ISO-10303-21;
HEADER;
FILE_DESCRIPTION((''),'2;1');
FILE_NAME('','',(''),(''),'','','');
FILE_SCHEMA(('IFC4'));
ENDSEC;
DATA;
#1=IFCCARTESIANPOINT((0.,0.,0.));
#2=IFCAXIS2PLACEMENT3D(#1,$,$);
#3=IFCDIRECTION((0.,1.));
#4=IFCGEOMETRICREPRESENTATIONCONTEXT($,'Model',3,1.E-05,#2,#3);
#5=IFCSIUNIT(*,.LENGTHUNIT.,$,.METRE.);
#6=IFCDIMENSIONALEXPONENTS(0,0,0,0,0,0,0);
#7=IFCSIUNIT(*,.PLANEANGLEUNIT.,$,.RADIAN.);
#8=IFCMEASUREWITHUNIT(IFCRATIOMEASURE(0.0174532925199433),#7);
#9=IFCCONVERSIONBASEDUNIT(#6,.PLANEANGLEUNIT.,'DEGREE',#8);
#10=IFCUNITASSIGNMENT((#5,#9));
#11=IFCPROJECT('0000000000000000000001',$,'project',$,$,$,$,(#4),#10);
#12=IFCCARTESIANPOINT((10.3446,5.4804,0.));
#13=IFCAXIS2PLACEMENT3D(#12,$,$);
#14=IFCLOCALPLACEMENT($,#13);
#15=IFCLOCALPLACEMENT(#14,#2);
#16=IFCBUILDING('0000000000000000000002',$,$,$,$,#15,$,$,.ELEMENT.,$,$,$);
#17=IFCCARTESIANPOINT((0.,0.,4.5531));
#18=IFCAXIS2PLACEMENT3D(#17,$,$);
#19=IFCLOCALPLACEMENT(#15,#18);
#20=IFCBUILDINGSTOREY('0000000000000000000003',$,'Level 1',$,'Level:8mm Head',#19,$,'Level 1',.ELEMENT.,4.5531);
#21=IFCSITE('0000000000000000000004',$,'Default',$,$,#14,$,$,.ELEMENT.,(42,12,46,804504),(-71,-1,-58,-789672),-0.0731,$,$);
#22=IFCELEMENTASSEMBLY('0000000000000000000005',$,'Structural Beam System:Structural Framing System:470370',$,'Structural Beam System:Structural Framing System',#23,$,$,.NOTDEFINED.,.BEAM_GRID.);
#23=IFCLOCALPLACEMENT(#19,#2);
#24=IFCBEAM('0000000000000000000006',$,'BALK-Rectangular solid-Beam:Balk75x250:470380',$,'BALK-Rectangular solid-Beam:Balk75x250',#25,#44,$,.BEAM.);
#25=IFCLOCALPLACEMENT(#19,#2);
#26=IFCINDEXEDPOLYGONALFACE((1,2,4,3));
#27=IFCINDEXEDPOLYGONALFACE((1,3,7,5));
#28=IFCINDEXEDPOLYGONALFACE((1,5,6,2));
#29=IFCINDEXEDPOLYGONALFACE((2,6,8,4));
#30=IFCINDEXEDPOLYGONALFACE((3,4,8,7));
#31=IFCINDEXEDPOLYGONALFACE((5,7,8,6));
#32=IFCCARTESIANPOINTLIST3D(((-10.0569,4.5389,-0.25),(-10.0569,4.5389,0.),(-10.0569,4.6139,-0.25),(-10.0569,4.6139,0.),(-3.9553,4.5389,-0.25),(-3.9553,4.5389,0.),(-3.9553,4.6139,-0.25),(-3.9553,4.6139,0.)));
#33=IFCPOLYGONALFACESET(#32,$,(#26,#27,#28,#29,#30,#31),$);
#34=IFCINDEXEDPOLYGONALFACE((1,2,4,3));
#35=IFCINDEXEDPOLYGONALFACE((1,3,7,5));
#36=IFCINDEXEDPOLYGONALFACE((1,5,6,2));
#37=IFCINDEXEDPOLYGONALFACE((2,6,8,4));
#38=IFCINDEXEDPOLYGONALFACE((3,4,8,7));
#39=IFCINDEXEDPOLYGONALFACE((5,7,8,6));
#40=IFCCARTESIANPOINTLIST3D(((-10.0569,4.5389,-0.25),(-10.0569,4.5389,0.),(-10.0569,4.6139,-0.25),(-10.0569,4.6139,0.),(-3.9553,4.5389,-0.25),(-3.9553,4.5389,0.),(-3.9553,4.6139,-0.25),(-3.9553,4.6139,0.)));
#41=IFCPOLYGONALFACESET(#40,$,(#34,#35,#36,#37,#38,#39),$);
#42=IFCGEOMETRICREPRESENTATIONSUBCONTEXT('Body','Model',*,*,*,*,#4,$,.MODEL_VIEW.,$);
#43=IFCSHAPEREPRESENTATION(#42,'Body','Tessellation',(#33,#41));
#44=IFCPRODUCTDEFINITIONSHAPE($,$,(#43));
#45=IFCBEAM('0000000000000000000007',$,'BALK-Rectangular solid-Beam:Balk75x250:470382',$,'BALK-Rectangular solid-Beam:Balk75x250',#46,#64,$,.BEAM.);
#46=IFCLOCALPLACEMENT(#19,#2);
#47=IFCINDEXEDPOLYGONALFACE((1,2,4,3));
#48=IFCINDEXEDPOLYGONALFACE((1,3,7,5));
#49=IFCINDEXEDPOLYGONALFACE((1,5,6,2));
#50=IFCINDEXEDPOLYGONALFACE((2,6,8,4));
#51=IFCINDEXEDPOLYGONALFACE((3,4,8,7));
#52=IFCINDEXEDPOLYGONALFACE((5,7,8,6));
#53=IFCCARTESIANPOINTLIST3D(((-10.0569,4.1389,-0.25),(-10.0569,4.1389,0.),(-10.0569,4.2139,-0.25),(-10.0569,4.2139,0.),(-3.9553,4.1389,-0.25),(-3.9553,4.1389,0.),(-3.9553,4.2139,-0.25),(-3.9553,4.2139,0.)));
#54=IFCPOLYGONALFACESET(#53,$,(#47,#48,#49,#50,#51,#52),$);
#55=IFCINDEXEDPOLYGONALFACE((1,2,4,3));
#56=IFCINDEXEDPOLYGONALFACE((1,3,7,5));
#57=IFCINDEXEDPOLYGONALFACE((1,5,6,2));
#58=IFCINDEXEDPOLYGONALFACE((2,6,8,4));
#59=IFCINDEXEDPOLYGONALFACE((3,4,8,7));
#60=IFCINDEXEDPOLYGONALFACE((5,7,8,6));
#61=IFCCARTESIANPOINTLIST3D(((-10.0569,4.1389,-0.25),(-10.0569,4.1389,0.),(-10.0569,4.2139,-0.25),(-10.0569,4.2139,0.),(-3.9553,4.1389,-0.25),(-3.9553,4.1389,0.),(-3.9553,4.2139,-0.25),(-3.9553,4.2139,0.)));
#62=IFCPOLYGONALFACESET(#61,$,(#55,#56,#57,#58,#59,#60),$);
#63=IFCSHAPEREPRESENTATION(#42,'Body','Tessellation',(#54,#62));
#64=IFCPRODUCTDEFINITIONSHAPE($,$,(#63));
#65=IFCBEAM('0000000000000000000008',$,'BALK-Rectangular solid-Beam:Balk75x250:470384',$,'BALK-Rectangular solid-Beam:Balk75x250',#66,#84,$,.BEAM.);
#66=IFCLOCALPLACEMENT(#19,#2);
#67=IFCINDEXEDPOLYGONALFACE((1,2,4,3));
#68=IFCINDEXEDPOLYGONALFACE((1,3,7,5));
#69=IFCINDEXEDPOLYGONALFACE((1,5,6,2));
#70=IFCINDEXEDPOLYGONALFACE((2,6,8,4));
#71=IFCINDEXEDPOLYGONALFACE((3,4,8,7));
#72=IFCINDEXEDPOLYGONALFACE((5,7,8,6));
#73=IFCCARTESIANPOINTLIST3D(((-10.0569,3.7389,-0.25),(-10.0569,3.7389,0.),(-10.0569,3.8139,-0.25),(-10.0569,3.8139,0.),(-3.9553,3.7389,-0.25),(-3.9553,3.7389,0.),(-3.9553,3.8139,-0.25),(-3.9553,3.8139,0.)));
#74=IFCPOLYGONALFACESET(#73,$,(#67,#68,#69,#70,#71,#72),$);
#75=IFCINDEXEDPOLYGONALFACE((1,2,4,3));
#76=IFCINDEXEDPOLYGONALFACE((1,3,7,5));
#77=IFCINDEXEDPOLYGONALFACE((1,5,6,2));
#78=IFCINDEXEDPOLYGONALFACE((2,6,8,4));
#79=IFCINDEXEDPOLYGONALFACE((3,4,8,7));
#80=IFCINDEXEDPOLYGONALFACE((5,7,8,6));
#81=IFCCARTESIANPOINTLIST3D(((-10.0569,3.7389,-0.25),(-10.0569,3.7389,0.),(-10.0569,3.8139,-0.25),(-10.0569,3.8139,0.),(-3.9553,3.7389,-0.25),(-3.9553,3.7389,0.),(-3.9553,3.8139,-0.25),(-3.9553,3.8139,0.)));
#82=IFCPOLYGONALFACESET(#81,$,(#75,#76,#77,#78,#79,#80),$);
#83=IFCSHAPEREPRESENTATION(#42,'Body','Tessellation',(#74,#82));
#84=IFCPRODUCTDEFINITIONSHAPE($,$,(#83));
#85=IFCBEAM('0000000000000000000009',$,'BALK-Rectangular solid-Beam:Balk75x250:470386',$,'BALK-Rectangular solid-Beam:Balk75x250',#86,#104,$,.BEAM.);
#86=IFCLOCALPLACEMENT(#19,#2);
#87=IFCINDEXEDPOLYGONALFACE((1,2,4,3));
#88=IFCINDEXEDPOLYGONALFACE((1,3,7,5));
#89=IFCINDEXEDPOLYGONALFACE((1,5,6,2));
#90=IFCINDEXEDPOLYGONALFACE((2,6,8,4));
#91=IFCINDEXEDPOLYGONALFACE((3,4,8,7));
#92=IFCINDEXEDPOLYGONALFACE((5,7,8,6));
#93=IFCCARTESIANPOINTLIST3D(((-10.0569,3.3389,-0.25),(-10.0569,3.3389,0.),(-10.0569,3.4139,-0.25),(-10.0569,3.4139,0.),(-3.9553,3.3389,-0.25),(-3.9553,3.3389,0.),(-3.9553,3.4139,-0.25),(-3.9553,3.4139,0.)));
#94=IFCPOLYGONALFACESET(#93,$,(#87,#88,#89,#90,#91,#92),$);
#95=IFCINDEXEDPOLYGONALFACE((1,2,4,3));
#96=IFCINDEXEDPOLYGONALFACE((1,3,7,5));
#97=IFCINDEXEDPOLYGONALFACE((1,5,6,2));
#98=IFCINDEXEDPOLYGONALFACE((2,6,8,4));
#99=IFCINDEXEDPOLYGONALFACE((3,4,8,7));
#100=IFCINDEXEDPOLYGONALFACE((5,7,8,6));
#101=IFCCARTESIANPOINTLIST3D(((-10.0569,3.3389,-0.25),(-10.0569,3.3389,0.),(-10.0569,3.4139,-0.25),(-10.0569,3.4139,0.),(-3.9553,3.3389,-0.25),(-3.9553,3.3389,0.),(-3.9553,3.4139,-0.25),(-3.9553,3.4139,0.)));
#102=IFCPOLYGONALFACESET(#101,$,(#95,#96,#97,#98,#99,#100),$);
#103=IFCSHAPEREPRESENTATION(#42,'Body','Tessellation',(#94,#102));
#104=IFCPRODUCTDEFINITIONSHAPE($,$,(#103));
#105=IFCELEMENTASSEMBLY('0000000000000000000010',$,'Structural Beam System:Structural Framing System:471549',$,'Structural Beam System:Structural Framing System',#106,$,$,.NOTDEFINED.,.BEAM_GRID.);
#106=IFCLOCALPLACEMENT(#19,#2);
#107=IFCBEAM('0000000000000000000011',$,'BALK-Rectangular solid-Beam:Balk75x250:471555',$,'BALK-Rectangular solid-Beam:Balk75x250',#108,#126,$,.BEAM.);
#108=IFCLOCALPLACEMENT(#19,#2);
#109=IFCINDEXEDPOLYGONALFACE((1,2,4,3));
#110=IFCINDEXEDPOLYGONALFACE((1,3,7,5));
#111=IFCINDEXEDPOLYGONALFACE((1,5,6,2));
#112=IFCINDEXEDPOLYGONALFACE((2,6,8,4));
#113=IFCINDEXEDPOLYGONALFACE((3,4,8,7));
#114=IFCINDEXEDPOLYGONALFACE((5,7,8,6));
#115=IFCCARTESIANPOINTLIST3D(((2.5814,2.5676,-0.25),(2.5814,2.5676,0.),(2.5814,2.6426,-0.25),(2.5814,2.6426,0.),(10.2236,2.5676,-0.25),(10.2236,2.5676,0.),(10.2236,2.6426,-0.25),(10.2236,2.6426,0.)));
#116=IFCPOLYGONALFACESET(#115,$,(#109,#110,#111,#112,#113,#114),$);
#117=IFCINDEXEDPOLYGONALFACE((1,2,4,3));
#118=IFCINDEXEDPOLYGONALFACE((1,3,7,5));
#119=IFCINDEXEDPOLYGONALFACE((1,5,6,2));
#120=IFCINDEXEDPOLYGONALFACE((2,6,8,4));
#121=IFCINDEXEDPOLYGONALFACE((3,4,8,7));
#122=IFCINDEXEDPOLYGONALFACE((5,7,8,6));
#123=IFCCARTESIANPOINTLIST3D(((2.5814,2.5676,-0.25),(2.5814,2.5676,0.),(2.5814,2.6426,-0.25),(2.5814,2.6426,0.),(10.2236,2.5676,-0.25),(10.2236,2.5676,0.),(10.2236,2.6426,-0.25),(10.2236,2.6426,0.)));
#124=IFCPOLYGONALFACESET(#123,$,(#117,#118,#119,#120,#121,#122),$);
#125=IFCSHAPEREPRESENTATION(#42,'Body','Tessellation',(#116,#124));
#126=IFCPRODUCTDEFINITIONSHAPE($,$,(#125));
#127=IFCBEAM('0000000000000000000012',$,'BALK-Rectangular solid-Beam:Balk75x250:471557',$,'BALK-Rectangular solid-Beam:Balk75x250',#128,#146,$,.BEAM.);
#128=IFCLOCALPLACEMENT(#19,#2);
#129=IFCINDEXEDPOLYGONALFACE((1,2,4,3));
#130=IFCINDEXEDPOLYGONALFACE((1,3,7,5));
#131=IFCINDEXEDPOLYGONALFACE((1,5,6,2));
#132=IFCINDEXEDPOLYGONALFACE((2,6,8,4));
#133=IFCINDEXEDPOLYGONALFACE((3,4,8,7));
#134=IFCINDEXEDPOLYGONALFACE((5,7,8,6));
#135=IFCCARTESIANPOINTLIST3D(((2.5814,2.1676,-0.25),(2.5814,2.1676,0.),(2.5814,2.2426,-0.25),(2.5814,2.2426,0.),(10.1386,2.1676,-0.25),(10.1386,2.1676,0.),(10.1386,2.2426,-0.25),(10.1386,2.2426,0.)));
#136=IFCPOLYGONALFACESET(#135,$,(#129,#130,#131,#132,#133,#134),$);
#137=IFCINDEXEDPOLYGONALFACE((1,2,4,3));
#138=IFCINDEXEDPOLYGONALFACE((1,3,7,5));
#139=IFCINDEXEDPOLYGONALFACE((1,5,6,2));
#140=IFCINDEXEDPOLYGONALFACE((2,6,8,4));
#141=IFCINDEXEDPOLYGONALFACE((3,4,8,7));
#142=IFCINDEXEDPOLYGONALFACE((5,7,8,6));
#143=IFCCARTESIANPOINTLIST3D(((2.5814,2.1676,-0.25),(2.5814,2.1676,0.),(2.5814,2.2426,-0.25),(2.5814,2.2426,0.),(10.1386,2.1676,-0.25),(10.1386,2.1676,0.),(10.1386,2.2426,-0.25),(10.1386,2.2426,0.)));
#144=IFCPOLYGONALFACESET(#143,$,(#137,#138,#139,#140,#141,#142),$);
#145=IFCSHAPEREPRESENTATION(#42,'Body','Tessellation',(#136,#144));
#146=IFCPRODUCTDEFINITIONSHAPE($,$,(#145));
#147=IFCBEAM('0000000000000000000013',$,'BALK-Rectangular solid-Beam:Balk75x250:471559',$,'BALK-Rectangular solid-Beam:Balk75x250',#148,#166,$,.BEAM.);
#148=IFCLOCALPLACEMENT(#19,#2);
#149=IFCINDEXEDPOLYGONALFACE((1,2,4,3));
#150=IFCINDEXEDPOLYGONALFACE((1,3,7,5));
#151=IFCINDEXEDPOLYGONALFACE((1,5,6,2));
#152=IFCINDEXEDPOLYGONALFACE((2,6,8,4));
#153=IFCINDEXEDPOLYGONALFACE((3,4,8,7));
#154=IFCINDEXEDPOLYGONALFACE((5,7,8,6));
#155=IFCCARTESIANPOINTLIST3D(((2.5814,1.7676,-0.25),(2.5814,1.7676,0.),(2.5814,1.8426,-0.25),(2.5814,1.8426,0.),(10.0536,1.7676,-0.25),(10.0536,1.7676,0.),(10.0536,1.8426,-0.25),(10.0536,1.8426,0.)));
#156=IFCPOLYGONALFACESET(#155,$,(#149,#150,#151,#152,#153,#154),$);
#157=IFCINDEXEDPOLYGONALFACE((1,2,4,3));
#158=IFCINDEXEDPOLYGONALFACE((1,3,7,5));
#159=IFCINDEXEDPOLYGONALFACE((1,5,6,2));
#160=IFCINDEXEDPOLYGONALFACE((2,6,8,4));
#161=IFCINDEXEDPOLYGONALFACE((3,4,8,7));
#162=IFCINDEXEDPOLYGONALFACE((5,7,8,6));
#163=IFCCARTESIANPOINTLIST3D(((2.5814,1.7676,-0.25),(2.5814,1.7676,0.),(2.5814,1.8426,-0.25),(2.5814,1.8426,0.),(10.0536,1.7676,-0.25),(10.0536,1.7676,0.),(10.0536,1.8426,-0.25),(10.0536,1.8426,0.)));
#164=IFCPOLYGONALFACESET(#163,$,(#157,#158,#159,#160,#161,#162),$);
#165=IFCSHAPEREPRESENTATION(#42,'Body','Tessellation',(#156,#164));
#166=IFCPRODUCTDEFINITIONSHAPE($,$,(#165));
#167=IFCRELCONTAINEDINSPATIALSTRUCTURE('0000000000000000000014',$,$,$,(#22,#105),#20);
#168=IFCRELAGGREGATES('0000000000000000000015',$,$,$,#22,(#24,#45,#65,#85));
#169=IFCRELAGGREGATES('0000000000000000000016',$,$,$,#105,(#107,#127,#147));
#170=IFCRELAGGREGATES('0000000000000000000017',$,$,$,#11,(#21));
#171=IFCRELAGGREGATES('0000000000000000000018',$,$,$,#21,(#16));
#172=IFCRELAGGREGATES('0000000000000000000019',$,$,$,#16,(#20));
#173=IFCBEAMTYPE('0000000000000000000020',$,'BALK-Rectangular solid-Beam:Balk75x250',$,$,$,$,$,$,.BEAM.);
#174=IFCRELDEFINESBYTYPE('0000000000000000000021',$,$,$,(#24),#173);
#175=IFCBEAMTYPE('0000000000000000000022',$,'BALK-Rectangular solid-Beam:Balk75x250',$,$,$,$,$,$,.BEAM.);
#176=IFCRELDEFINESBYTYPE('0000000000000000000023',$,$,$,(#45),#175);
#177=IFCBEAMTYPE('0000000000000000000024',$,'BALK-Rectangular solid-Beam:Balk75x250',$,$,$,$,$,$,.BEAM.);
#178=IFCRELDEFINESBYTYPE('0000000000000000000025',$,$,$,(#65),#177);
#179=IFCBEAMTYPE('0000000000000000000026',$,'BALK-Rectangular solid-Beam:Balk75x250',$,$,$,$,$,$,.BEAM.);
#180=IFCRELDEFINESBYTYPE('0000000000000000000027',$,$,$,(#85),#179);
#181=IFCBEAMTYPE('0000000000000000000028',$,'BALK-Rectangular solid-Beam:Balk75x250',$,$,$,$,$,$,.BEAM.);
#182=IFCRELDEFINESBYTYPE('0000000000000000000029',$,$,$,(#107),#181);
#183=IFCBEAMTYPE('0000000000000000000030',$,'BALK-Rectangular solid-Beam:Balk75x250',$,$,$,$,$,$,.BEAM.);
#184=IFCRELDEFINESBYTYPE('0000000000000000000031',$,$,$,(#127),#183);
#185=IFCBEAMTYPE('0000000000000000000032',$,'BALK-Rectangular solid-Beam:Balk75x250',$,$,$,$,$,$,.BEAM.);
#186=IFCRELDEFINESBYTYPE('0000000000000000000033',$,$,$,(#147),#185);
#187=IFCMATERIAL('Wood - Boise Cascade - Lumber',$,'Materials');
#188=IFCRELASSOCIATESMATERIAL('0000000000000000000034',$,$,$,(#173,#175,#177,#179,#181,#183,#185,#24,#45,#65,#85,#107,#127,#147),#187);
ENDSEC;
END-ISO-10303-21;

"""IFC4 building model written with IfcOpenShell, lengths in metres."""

from ifc_helpers import new_model, entity, si_unit, converted_unit, direction, frame, frame_2d, origin, place, context, subcontext, project, spatial, rectangle, extrude, source, transform, mapped, material, material_profile, profile_set, profile_usage, type_object, type_shapes, element, aggregate, save


model = new_model("IFC4")

# Units and contexts
model_context = context("Model", 3, precision=1e-05, world=origin(), true_north=direction((0.0, 1.0)))
body_context = subcontext(model_context, "Body", "Model", "MODEL_VIEW")
ifc_project = project(units=[si_unit("LENGTHUNIT", "METRE"), converted_unit("PLANEANGLEUNIT", "DEGREE", entity("IfcRatioMeasure", 0.0174532925199433), si_unit("PLANEANGLEUNIT", "RADIAN"), dimensions=[0, 0, 0, 0, 0, 0, 0])], contexts=[model_context])

# Site, building, storey
site_placement = place(None, frame((10.3446, 5.4804, 0.0)))
site = spatial("IfcSite", under=ifc_project, at=site_placement, Name="Default", CompositionType="ELEMENT", RefLatitude=(42, 12, 46, 804504), RefLongitude=(-71, -1, -58, -789672), RefElevation=-0.0731)
building_placement = place(site_placement, origin())
building = spatial("IfcBuilding", under=site, at=building_placement, CompositionType="ELEMENT")
storey_placement = place(building_placement, frame((0.0, 0.0, 4.5531)))
storey = spatial("IfcBuildingStorey", under=building, at=storey_placement, Name="Level 1", ObjectType="Level:8mm Head", LongName="Level 1", CompositionType="ELEMENT", Elevation=4.5531)

# Element assemblies, beams
assembly_1_placement = place(storey_placement, origin())
assembly_1 = element("IfcElementAssembly", 1, at=assembly_1_placement, inside=storey, Name="Structural Beam System:Structural Framing System:470370", ObjectType="Structural Beam System:Structural Framing System", AssemblyPlace="NOTDEFINED", PredefinedType="BEAM_GRID")
ifc_material = material(Name="Wood - Boise Cascade - Lumber", Category="Materials")
ifc_material_profile = material_profile(ifc_material, rectangle(XDim=0.25, YDim=0.075, at=frame_2d((0.0, 0.0), x_axis=(1.0, 0.0))), Name="Balk75x250")
ifc_profile_set = profile_set([ifc_material_profile], Name="Balk75x250")
ifc_profile_usage_1 = profile_usage(ifc_profile_set, cardinal=8)
beam_type_1 = type_object("IfcBeamType", Name="BALK-Rectangular solid-Beam:Balk75x250", PredefinedType="BEAM", material=ifc_profile_set)
shared_shape_1 = source(origin(), body_context, "Body", "SweptSolid", [
    extrude(rectangle(XDim=0.25, YDim=0.075, at=frame_2d((0.0, 0.0), x_axis=(1.0, 0.0))), frame((-10.0569, 4.5764, 4.4281), z_axis=(1.0, 0.0, 0.0), x_axis=(0.0, 0.0, -1.0)), (0.0, 0.0, 1.0), 6.1016),
    extrude(rectangle(XDim=0.25, YDim=0.075, at=frame_2d((0.0, 0.0), x_axis=(1.0, 0.0))), frame((-10.0569, 4.5764, 4.4281), z_axis=(1.0, 0.0, 0.0), x_axis=(0.0, 0.0, -1.0)), (0.0, 0.0, 1.0), 6.1016),
])
type_shapes(beam_type_1, [shared_shape_1])
beam_1_placement = place(assembly_1_placement, frame((0.0, 0.0, -4.5531)))
beam_1 = element("IfcBeam", 2, at=beam_1_placement, type_object=beam_type_1, material=ifc_profile_usage_1, Name="BALK-Rectangular solid-Beam:Balk75x250:470380", ObjectType="BALK-Rectangular solid-Beam:Balk75x250", PredefinedType="BEAM", context=body_context, shape_type="MappedRepresentation", body=[
    mapped(shared_shape_1, transform((0.0, 0.0, 0.0), scale=1.0)),
])
ifc_profile_usage_2 = profile_usage(ifc_profile_set, cardinal=8)
beam_type_2 = type_object("IfcBeamType", Name="BALK-Rectangular solid-Beam:Balk75x250", PredefinedType="BEAM", material=ifc_profile_set)
shared_shape_2 = source(origin(), body_context, "Body", "SweptSolid", [
    extrude(rectangle(XDim=0.25, YDim=0.075, at=frame_2d((0.0, 0.0), x_axis=(1.0, 0.0))), frame((-10.0569, 4.1764, 4.4281), z_axis=(1.0, 0.0, 0.0), x_axis=(0.0, 0.0, -1.0)), (0.0, 0.0, 1.0), 6.1016),
    extrude(rectangle(XDim=0.25, YDim=0.075, at=frame_2d((0.0, 0.0), x_axis=(1.0, 0.0))), frame((-10.0569, 4.1764, 4.4281), z_axis=(1.0, 0.0, 0.0), x_axis=(0.0, 0.0, -1.0)), (0.0, 0.0, 1.0), 6.1016),
])
type_shapes(beam_type_2, [shared_shape_2])
beam_2_placement = place(assembly_1_placement, frame((0.0, 0.0, -4.5531)))
beam_2 = element("IfcBeam", 3, at=beam_2_placement, type_object=beam_type_2, material=ifc_profile_usage_2, Name="BALK-Rectangular solid-Beam:Balk75x250:470382", ObjectType="BALK-Rectangular solid-Beam:Balk75x250", PredefinedType="BEAM", context=body_context, shape_type="MappedRepresentation", body=[
    mapped(shared_shape_2, transform((0.0, 0.0, 0.0), scale=1.0)),
])
ifc_profile_usage_3 = profile_usage(ifc_profile_set, cardinal=8)
beam_type_3 = type_object("IfcBeamType", Name="BALK-Rectangular solid-Beam:Balk75x250", PredefinedType="BEAM", material=ifc_profile_set)
shared_shape_3 = source(origin(), body_context, "Body", "SweptSolid", [
    extrude(rectangle(XDim=0.25, YDim=0.075, at=frame_2d((0.0, 0.0), x_axis=(1.0, 0.0))), frame((-10.0569, 3.7764, 4.4281), z_axis=(1.0, 0.0, 0.0), x_axis=(0.0, 0.0, -1.0)), (0.0, 0.0, 1.0), 6.1016),
    extrude(rectangle(XDim=0.25, YDim=0.075, at=frame_2d((0.0, 0.0), x_axis=(1.0, 0.0))), frame((-10.0569, 3.7764, 4.4281), z_axis=(1.0, 0.0, 0.0), x_axis=(0.0, 0.0, -1.0)), (0.0, 0.0, 1.0), 6.1016),
])
type_shapes(beam_type_3, [shared_shape_3])
beam_3_placement = place(assembly_1_placement, frame((0.0, 0.0, -4.5531)))
beam_3 = element("IfcBeam", 4, at=beam_3_placement, type_object=beam_type_3, material=ifc_profile_usage_3, Name="BALK-Rectangular solid-Beam:Balk75x250:470384", ObjectType="BALK-Rectangular solid-Beam:Balk75x250", PredefinedType="BEAM", context=body_context, shape_type="MappedRepresentation", body=[
    mapped(shared_shape_3, transform((0.0, 0.0, 0.0), scale=1.0)),
])
ifc_profile_usage_4 = profile_usage(ifc_profile_set, cardinal=8)
beam_type_4 = type_object("IfcBeamType", Name="BALK-Rectangular solid-Beam:Balk75x250", PredefinedType="BEAM", material=ifc_profile_set)
shared_shape_4 = source(origin(), body_context, "Body", "SweptSolid", [
    extrude(rectangle(XDim=0.25, YDim=0.075, at=frame_2d((0.0, 0.0), x_axis=(1.0, 0.0))), frame((-10.0569, 3.3764, 4.4281), z_axis=(1.0, 0.0, 0.0), x_axis=(0.0, 0.0, -1.0)), (0.0, 0.0, 1.0), 6.1016),
    extrude(rectangle(XDim=0.25, YDim=0.075, at=frame_2d((0.0, 0.0), x_axis=(1.0, 0.0))), frame((-10.0569, 3.3764, 4.4281), z_axis=(1.0, 0.0, 0.0), x_axis=(0.0, 0.0, -1.0)), (0.0, 0.0, 1.0), 6.1016),
])
type_shapes(beam_type_4, [shared_shape_4])
beam_4_placement = place(assembly_1_placement, frame((0.0, 0.0, -4.5531)))
beam_4 = element("IfcBeam", 5, at=beam_4_placement, type_object=beam_type_4, material=ifc_profile_usage_4, Name="BALK-Rectangular solid-Beam:Balk75x250:470386", ObjectType="BALK-Rectangular solid-Beam:Balk75x250", PredefinedType="BEAM", context=body_context, shape_type="MappedRepresentation", body=[
    mapped(shared_shape_4, transform((0.0, 0.0, 0.0), scale=1.0)),
])
aggregate(assembly_1, [beam_1, beam_2, beam_3, beam_4])
assembly_2_placement = place(storey_placement, origin())
assembly_2 = element("IfcElementAssembly", 6, at=assembly_2_placement, inside=storey, Name="Structural Beam System:Structural Framing System:471549", ObjectType="Structural Beam System:Structural Framing System", AssemblyPlace="NOTDEFINED", PredefinedType="BEAM_GRID")
ifc_profile_usage_5 = profile_usage(ifc_profile_set, cardinal=8)
beam_type_5 = type_object("IfcBeamType", Name="BALK-Rectangular solid-Beam:Balk75x250", PredefinedType="BEAM", material=ifc_profile_set)
shared_shape_5 = source(origin(), body_context, "Body", "SweptSolid", [
    extrude(rectangle(XDim=0.25, YDim=0.075, at=frame_2d((0.0, 0.0), x_axis=(1.0, 0.0))), frame((2.5814, 2.6051, 4.4281), z_axis=(1.0, 0.0, 0.0), x_axis=(0.0, 0.0, -1.0)), (0.0, 0.0, 1.0), 7.6423),
    extrude(rectangle(XDim=0.25, YDim=0.075, at=frame_2d((0.0, 0.0), x_axis=(1.0, 0.0))), frame((2.5814, 2.6051, 4.4281), z_axis=(1.0, 0.0, 0.0), x_axis=(0.0, 0.0, -1.0)), (0.0, 0.0, 1.0), 7.6423),
])
type_shapes(beam_type_5, [shared_shape_5])
beam_5_placement = place(assembly_2_placement, frame((0.0, 0.0, -4.5531)))
beam_5 = element("IfcBeam", 7, at=beam_5_placement, type_object=beam_type_5, material=ifc_profile_usage_5, Name="BALK-Rectangular solid-Beam:Balk75x250:471555", ObjectType="BALK-Rectangular solid-Beam:Balk75x250", PredefinedType="BEAM", context=body_context, shape_type="MappedRepresentation", body=[
    mapped(shared_shape_5, transform((0.0, 0.0, 0.0), scale=1.0)),
])
ifc_profile_usage_6 = profile_usage(ifc_profile_set, cardinal=8)
beam_type_6 = type_object("IfcBeamType", Name="BALK-Rectangular solid-Beam:Balk75x250", PredefinedType="BEAM", material=ifc_profile_set)
shared_shape_6 = source(origin(), body_context, "Body", "SweptSolid", [
    extrude(rectangle(XDim=0.25, YDim=0.075, at=frame_2d((0.0, 0.0), x_axis=(1.0, 0.0))), frame((2.5814, 2.2051, 4.4281), z_axis=(1.0, 0.0, 0.0), x_axis=(0.0, 0.0, -1.0)), (0.0, 0.0, 1.0), 7.5573),
    extrude(rectangle(XDim=0.25, YDim=0.075, at=frame_2d((0.0, 0.0), x_axis=(1.0, 0.0))), frame((2.5814, 2.2051, 4.4281), z_axis=(1.0, 0.0, 0.0), x_axis=(0.0, 0.0, -1.0)), (0.0, 0.0, 1.0), 7.5573),
])
type_shapes(beam_type_6, [shared_shape_6])
beam_6_placement = place(assembly_2_placement, frame((0.0, 0.0, -4.5531)))
beam_6 = element("IfcBeam", 8, at=beam_6_placement, type_object=beam_type_6, material=ifc_profile_usage_6, Name="BALK-Rectangular solid-Beam:Balk75x250:471557", ObjectType="BALK-Rectangular solid-Beam:Balk75x250", PredefinedType="BEAM", context=body_context, shape_type="MappedRepresentation", body=[
    mapped(shared_shape_6, transform((0.0, 0.0, 0.0), scale=1.0)),
])
ifc_profile_usage_7 = profile_usage(ifc_profile_set, cardinal=8)
beam_type_7 = type_object("IfcBeamType", Name="BALK-Rectangular solid-Beam:Balk75x250", PredefinedType="BEAM", material=ifc_profile_set)
shared_shape_7 = source(origin(), body_context, "Body", "SweptSolid", [
    extrude(rectangle(XDim=0.25, YDim=0.075, at=frame_2d((0.0, 0.0), x_axis=(1.0, 0.0))), frame((2.5814, 1.8051, 4.4281), z_axis=(1.0, 0.0, 0.0), x_axis=(0.0, 0.0, -1.0)), (0.0, 0.0, 1.0), 7.4722),
    extrude(rectangle(XDim=0.25, YDim=0.075, at=frame_2d((0.0, 0.0), x_axis=(1.0, 0.0))), frame((2.5814, 1.8051, 4.4281), z_axis=(1.0, 0.0, 0.0), x_axis=(0.0, 0.0, -1.0)), (0.0, 0.0, 1.0), 7.4722),
])
type_shapes(beam_type_7, [shared_shape_7])
beam_7_placement = place(assembly_2_placement, frame((0.0, 0.0, -4.5531)))
beam_7 = element("IfcBeam", 9, at=beam_7_placement, type_object=beam_type_7, material=ifc_profile_usage_7, Name="BALK-Rectangular solid-Beam:Balk75x250:471559", ObjectType="BALK-Rectangular solid-Beam:Balk75x250", PredefinedType="BEAM", context=body_context, shape_type="MappedRepresentation", body=[
    mapped(shared_shape_7, transform((0.0, 0.0, 0.0), scale=1.0)),
])
aggregate(assembly_2, [beam_5, beam_6, beam_7])

save(model, "model.ifc")
